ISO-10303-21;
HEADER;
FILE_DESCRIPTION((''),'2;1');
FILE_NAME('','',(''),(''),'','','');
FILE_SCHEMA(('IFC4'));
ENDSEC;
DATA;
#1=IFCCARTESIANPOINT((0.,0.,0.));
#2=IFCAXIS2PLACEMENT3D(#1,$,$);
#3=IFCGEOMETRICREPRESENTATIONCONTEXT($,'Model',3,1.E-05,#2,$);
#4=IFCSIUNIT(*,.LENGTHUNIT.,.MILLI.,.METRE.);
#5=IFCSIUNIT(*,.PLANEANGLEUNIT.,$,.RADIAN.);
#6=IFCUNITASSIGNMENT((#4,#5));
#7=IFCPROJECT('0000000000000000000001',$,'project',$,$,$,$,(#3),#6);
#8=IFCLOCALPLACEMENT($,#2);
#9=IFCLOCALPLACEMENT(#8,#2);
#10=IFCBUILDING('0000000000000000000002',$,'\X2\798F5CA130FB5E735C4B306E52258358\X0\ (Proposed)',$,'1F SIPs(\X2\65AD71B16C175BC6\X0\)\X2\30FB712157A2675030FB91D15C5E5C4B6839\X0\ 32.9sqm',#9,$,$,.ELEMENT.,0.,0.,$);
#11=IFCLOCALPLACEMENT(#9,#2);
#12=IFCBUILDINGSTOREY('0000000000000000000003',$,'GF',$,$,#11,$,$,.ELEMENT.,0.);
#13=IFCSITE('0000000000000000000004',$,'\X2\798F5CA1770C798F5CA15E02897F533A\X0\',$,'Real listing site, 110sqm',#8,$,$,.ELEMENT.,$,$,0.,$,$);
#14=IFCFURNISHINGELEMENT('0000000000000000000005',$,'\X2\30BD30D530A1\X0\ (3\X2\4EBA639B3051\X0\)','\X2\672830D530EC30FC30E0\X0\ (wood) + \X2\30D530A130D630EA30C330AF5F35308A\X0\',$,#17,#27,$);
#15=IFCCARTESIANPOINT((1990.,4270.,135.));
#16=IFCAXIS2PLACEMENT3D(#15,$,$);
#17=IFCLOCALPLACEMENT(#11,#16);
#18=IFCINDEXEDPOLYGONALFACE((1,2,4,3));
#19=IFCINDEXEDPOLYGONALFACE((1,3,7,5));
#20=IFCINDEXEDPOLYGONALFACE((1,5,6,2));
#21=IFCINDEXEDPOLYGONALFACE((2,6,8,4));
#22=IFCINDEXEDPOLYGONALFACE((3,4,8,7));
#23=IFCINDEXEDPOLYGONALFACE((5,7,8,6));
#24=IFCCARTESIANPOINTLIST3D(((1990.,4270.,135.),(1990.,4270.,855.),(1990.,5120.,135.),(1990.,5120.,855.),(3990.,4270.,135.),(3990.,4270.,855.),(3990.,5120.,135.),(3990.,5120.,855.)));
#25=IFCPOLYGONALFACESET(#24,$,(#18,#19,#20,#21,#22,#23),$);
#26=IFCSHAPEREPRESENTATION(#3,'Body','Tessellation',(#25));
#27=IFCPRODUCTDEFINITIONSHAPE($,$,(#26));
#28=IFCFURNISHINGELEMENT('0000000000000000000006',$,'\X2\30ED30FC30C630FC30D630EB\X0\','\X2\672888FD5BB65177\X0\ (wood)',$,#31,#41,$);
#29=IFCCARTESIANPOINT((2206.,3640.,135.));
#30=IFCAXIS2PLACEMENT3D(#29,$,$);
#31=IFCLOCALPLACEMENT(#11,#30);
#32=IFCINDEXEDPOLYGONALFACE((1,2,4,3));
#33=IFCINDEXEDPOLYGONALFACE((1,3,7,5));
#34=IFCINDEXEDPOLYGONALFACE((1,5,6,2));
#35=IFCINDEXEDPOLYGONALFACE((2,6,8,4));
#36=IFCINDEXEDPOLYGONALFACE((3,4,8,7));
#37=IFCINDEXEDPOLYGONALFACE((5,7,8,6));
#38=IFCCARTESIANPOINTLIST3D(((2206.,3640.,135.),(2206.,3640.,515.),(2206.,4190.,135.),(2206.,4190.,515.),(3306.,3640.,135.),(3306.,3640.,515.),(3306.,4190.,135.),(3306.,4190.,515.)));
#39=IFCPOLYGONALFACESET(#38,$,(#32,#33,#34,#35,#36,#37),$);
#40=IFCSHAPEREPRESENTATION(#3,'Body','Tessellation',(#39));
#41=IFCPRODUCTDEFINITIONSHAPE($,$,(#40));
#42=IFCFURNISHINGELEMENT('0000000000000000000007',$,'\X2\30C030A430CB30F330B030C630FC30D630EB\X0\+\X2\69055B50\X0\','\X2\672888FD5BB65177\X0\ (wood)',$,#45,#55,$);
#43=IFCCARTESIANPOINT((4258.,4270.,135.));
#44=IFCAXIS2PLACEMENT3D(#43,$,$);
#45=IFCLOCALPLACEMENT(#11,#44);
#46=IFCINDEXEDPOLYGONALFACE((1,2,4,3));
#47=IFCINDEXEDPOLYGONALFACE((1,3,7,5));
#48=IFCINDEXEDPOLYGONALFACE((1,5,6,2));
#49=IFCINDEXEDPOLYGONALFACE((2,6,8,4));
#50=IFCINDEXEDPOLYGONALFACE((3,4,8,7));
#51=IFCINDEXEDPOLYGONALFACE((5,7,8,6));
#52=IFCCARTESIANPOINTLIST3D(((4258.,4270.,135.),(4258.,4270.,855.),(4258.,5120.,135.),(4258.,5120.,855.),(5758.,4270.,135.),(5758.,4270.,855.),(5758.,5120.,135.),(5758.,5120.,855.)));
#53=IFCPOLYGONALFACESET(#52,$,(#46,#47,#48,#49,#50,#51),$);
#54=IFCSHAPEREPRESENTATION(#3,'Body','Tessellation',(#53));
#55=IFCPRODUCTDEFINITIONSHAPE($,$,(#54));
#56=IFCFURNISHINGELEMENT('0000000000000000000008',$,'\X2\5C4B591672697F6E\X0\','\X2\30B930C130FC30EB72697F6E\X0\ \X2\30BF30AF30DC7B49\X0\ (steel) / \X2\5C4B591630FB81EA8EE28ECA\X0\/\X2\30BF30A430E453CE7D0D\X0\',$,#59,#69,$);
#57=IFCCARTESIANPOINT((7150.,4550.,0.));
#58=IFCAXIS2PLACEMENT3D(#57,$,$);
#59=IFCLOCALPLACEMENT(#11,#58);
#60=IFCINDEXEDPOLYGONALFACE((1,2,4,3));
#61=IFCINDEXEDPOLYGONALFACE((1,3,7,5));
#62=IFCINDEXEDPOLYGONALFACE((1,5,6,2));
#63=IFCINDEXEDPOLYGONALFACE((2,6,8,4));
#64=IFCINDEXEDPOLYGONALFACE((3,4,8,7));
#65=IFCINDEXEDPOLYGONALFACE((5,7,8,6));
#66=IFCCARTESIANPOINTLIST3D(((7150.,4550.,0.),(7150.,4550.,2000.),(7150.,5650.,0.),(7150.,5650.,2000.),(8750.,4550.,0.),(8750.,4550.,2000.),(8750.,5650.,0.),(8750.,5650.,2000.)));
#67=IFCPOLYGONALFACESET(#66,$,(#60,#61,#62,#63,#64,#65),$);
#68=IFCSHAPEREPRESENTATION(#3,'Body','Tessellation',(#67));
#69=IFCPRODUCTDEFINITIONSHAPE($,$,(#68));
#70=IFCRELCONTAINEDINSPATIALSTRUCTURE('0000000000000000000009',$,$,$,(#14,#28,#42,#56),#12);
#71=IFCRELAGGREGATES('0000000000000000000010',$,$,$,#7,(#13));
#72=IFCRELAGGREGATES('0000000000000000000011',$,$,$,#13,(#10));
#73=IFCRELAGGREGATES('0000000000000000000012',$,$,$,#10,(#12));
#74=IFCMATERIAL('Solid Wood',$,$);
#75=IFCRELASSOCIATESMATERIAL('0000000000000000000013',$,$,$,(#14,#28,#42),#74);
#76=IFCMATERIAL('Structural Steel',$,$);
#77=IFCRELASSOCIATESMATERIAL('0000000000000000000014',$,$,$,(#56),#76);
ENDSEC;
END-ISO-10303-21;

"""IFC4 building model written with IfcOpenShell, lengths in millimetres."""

from ifc_helpers import new_model, si_unit, frame, frame_2d, origin, place, context, project, spatial, rectangle, extrude, material, element, save


model = new_model("IFC4")

# Units and contexts
model_context = context("Model", 3, precision=1e-05, world=origin())
ifc_project = project(units=[si_unit("LENGTHUNIT", "METRE", prefix="MILLI"), si_unit("PLANEANGLEUNIT", "RADIAN")], contexts=[model_context])

# Site, building, storey
site_placement = place(None, origin())
site = spatial("IfcSite", under=ifc_project, at=site_placement, Name="福岡県福岡市西区", ObjectType="Real listing site, 110sqm", CompositionType="ELEMENT", RefElevation=0.0)
building_placement = place(site_placement, origin())
building = spatial("IfcBuilding", under=site, at=building_placement, Name="福岡・平屋の別荘 (Proposed)", ObjectType="1F SIPs(断熱気密)・無垢材・金属屋根 32.9sqm", CompositionType="ELEMENT", ElevationOfRefHeight=0.0, ElevationOfTerrain=0.0)
storey_placement = place(building_placement, origin())
storey = spatial("IfcBuildingStorey", under=building, at=storey_placement, Name="GF", CompositionType="ELEMENT", Elevation=0.0)

# Shared definitions
ifc_material_1 = material(Name="Solid Wood")

# Shared definitions
ifc_material_2 = material(Name="Structural Steel")

# Furnishing elements
furnishing_1_placement = place(storey_placement, frame((1990.0, 4270.0, 135.0)))
element("IfcFurnishingElement", 1, at=furnishing_1_placement, inside=storey, material=ifc_material_1, Name="ソファ (3人掛け)", Description="木フレーム (wood) + ファブリック張り", context=model_context, shape_type="SweptSolid", body=[
    extrude(rectangle(XDim=2000.0, YDim=850.0, at=frame_2d((1000.0, 425.0))), frame((1990.0, 4270.0, 135.0)), (0.0, 0.0, 1.0), 720.0),
])
furnishing_2_placement = place(storey_placement, frame((2206.0, 3640.0, 135.0)))
element("IfcFurnishingElement", 2, at=furnishing_2_placement, inside=storey, material=ifc_material_1, Name="ローテーブル", Description="木製家具 (wood)", context=model_context, shape_type="SweptSolid", body=[
    extrude(rectangle(XDim=1100.0, YDim=550.0, at=frame_2d((550.0, 275.0))), frame((2206.0, 3640.0, 135.0)), (0.0, 0.0, 1.0), 380.0),
])
furnishing_3_placement = place(storey_placement, frame((4258.0, 4270.0, 135.0)))
element("IfcFurnishingElement", 3, at=furnishing_3_placement, inside=storey, material=ifc_material_1, Name="ダイニングテーブル+椅子", Description="木製家具 (wood)", context=model_context, shape_type="SweptSolid", body=[
    extrude(rectangle(XDim=1500.0, YDim=850.0, at=frame_2d((750.0, 425.0))), frame((4258.0, 4270.0, 135.0)), (0.0, 0.0, 1.0), 720.0),
])
furnishing_4_placement = place(storey_placement, frame((7150.0, 4550.0, 0.0)))
element("IfcFurnishingElement", 4, at=furnishing_4_placement, inside=storey, material=ifc_material_2, Name="屋外物置", Description="スチール物置 タクボ等 (steel) / 屋外・自転車/タイヤ収納", context=model_context, shape_type="SweptSolid", body=[
    extrude(rectangle(XDim=1600.0, YDim=1100.0, at=frame_2d((800.0, 550.0))), frame((7150.0, 4550.0, 0.0)), (0.0, 0.0, 1.0), 2000.0),
])

save(model, "model.ifc")
